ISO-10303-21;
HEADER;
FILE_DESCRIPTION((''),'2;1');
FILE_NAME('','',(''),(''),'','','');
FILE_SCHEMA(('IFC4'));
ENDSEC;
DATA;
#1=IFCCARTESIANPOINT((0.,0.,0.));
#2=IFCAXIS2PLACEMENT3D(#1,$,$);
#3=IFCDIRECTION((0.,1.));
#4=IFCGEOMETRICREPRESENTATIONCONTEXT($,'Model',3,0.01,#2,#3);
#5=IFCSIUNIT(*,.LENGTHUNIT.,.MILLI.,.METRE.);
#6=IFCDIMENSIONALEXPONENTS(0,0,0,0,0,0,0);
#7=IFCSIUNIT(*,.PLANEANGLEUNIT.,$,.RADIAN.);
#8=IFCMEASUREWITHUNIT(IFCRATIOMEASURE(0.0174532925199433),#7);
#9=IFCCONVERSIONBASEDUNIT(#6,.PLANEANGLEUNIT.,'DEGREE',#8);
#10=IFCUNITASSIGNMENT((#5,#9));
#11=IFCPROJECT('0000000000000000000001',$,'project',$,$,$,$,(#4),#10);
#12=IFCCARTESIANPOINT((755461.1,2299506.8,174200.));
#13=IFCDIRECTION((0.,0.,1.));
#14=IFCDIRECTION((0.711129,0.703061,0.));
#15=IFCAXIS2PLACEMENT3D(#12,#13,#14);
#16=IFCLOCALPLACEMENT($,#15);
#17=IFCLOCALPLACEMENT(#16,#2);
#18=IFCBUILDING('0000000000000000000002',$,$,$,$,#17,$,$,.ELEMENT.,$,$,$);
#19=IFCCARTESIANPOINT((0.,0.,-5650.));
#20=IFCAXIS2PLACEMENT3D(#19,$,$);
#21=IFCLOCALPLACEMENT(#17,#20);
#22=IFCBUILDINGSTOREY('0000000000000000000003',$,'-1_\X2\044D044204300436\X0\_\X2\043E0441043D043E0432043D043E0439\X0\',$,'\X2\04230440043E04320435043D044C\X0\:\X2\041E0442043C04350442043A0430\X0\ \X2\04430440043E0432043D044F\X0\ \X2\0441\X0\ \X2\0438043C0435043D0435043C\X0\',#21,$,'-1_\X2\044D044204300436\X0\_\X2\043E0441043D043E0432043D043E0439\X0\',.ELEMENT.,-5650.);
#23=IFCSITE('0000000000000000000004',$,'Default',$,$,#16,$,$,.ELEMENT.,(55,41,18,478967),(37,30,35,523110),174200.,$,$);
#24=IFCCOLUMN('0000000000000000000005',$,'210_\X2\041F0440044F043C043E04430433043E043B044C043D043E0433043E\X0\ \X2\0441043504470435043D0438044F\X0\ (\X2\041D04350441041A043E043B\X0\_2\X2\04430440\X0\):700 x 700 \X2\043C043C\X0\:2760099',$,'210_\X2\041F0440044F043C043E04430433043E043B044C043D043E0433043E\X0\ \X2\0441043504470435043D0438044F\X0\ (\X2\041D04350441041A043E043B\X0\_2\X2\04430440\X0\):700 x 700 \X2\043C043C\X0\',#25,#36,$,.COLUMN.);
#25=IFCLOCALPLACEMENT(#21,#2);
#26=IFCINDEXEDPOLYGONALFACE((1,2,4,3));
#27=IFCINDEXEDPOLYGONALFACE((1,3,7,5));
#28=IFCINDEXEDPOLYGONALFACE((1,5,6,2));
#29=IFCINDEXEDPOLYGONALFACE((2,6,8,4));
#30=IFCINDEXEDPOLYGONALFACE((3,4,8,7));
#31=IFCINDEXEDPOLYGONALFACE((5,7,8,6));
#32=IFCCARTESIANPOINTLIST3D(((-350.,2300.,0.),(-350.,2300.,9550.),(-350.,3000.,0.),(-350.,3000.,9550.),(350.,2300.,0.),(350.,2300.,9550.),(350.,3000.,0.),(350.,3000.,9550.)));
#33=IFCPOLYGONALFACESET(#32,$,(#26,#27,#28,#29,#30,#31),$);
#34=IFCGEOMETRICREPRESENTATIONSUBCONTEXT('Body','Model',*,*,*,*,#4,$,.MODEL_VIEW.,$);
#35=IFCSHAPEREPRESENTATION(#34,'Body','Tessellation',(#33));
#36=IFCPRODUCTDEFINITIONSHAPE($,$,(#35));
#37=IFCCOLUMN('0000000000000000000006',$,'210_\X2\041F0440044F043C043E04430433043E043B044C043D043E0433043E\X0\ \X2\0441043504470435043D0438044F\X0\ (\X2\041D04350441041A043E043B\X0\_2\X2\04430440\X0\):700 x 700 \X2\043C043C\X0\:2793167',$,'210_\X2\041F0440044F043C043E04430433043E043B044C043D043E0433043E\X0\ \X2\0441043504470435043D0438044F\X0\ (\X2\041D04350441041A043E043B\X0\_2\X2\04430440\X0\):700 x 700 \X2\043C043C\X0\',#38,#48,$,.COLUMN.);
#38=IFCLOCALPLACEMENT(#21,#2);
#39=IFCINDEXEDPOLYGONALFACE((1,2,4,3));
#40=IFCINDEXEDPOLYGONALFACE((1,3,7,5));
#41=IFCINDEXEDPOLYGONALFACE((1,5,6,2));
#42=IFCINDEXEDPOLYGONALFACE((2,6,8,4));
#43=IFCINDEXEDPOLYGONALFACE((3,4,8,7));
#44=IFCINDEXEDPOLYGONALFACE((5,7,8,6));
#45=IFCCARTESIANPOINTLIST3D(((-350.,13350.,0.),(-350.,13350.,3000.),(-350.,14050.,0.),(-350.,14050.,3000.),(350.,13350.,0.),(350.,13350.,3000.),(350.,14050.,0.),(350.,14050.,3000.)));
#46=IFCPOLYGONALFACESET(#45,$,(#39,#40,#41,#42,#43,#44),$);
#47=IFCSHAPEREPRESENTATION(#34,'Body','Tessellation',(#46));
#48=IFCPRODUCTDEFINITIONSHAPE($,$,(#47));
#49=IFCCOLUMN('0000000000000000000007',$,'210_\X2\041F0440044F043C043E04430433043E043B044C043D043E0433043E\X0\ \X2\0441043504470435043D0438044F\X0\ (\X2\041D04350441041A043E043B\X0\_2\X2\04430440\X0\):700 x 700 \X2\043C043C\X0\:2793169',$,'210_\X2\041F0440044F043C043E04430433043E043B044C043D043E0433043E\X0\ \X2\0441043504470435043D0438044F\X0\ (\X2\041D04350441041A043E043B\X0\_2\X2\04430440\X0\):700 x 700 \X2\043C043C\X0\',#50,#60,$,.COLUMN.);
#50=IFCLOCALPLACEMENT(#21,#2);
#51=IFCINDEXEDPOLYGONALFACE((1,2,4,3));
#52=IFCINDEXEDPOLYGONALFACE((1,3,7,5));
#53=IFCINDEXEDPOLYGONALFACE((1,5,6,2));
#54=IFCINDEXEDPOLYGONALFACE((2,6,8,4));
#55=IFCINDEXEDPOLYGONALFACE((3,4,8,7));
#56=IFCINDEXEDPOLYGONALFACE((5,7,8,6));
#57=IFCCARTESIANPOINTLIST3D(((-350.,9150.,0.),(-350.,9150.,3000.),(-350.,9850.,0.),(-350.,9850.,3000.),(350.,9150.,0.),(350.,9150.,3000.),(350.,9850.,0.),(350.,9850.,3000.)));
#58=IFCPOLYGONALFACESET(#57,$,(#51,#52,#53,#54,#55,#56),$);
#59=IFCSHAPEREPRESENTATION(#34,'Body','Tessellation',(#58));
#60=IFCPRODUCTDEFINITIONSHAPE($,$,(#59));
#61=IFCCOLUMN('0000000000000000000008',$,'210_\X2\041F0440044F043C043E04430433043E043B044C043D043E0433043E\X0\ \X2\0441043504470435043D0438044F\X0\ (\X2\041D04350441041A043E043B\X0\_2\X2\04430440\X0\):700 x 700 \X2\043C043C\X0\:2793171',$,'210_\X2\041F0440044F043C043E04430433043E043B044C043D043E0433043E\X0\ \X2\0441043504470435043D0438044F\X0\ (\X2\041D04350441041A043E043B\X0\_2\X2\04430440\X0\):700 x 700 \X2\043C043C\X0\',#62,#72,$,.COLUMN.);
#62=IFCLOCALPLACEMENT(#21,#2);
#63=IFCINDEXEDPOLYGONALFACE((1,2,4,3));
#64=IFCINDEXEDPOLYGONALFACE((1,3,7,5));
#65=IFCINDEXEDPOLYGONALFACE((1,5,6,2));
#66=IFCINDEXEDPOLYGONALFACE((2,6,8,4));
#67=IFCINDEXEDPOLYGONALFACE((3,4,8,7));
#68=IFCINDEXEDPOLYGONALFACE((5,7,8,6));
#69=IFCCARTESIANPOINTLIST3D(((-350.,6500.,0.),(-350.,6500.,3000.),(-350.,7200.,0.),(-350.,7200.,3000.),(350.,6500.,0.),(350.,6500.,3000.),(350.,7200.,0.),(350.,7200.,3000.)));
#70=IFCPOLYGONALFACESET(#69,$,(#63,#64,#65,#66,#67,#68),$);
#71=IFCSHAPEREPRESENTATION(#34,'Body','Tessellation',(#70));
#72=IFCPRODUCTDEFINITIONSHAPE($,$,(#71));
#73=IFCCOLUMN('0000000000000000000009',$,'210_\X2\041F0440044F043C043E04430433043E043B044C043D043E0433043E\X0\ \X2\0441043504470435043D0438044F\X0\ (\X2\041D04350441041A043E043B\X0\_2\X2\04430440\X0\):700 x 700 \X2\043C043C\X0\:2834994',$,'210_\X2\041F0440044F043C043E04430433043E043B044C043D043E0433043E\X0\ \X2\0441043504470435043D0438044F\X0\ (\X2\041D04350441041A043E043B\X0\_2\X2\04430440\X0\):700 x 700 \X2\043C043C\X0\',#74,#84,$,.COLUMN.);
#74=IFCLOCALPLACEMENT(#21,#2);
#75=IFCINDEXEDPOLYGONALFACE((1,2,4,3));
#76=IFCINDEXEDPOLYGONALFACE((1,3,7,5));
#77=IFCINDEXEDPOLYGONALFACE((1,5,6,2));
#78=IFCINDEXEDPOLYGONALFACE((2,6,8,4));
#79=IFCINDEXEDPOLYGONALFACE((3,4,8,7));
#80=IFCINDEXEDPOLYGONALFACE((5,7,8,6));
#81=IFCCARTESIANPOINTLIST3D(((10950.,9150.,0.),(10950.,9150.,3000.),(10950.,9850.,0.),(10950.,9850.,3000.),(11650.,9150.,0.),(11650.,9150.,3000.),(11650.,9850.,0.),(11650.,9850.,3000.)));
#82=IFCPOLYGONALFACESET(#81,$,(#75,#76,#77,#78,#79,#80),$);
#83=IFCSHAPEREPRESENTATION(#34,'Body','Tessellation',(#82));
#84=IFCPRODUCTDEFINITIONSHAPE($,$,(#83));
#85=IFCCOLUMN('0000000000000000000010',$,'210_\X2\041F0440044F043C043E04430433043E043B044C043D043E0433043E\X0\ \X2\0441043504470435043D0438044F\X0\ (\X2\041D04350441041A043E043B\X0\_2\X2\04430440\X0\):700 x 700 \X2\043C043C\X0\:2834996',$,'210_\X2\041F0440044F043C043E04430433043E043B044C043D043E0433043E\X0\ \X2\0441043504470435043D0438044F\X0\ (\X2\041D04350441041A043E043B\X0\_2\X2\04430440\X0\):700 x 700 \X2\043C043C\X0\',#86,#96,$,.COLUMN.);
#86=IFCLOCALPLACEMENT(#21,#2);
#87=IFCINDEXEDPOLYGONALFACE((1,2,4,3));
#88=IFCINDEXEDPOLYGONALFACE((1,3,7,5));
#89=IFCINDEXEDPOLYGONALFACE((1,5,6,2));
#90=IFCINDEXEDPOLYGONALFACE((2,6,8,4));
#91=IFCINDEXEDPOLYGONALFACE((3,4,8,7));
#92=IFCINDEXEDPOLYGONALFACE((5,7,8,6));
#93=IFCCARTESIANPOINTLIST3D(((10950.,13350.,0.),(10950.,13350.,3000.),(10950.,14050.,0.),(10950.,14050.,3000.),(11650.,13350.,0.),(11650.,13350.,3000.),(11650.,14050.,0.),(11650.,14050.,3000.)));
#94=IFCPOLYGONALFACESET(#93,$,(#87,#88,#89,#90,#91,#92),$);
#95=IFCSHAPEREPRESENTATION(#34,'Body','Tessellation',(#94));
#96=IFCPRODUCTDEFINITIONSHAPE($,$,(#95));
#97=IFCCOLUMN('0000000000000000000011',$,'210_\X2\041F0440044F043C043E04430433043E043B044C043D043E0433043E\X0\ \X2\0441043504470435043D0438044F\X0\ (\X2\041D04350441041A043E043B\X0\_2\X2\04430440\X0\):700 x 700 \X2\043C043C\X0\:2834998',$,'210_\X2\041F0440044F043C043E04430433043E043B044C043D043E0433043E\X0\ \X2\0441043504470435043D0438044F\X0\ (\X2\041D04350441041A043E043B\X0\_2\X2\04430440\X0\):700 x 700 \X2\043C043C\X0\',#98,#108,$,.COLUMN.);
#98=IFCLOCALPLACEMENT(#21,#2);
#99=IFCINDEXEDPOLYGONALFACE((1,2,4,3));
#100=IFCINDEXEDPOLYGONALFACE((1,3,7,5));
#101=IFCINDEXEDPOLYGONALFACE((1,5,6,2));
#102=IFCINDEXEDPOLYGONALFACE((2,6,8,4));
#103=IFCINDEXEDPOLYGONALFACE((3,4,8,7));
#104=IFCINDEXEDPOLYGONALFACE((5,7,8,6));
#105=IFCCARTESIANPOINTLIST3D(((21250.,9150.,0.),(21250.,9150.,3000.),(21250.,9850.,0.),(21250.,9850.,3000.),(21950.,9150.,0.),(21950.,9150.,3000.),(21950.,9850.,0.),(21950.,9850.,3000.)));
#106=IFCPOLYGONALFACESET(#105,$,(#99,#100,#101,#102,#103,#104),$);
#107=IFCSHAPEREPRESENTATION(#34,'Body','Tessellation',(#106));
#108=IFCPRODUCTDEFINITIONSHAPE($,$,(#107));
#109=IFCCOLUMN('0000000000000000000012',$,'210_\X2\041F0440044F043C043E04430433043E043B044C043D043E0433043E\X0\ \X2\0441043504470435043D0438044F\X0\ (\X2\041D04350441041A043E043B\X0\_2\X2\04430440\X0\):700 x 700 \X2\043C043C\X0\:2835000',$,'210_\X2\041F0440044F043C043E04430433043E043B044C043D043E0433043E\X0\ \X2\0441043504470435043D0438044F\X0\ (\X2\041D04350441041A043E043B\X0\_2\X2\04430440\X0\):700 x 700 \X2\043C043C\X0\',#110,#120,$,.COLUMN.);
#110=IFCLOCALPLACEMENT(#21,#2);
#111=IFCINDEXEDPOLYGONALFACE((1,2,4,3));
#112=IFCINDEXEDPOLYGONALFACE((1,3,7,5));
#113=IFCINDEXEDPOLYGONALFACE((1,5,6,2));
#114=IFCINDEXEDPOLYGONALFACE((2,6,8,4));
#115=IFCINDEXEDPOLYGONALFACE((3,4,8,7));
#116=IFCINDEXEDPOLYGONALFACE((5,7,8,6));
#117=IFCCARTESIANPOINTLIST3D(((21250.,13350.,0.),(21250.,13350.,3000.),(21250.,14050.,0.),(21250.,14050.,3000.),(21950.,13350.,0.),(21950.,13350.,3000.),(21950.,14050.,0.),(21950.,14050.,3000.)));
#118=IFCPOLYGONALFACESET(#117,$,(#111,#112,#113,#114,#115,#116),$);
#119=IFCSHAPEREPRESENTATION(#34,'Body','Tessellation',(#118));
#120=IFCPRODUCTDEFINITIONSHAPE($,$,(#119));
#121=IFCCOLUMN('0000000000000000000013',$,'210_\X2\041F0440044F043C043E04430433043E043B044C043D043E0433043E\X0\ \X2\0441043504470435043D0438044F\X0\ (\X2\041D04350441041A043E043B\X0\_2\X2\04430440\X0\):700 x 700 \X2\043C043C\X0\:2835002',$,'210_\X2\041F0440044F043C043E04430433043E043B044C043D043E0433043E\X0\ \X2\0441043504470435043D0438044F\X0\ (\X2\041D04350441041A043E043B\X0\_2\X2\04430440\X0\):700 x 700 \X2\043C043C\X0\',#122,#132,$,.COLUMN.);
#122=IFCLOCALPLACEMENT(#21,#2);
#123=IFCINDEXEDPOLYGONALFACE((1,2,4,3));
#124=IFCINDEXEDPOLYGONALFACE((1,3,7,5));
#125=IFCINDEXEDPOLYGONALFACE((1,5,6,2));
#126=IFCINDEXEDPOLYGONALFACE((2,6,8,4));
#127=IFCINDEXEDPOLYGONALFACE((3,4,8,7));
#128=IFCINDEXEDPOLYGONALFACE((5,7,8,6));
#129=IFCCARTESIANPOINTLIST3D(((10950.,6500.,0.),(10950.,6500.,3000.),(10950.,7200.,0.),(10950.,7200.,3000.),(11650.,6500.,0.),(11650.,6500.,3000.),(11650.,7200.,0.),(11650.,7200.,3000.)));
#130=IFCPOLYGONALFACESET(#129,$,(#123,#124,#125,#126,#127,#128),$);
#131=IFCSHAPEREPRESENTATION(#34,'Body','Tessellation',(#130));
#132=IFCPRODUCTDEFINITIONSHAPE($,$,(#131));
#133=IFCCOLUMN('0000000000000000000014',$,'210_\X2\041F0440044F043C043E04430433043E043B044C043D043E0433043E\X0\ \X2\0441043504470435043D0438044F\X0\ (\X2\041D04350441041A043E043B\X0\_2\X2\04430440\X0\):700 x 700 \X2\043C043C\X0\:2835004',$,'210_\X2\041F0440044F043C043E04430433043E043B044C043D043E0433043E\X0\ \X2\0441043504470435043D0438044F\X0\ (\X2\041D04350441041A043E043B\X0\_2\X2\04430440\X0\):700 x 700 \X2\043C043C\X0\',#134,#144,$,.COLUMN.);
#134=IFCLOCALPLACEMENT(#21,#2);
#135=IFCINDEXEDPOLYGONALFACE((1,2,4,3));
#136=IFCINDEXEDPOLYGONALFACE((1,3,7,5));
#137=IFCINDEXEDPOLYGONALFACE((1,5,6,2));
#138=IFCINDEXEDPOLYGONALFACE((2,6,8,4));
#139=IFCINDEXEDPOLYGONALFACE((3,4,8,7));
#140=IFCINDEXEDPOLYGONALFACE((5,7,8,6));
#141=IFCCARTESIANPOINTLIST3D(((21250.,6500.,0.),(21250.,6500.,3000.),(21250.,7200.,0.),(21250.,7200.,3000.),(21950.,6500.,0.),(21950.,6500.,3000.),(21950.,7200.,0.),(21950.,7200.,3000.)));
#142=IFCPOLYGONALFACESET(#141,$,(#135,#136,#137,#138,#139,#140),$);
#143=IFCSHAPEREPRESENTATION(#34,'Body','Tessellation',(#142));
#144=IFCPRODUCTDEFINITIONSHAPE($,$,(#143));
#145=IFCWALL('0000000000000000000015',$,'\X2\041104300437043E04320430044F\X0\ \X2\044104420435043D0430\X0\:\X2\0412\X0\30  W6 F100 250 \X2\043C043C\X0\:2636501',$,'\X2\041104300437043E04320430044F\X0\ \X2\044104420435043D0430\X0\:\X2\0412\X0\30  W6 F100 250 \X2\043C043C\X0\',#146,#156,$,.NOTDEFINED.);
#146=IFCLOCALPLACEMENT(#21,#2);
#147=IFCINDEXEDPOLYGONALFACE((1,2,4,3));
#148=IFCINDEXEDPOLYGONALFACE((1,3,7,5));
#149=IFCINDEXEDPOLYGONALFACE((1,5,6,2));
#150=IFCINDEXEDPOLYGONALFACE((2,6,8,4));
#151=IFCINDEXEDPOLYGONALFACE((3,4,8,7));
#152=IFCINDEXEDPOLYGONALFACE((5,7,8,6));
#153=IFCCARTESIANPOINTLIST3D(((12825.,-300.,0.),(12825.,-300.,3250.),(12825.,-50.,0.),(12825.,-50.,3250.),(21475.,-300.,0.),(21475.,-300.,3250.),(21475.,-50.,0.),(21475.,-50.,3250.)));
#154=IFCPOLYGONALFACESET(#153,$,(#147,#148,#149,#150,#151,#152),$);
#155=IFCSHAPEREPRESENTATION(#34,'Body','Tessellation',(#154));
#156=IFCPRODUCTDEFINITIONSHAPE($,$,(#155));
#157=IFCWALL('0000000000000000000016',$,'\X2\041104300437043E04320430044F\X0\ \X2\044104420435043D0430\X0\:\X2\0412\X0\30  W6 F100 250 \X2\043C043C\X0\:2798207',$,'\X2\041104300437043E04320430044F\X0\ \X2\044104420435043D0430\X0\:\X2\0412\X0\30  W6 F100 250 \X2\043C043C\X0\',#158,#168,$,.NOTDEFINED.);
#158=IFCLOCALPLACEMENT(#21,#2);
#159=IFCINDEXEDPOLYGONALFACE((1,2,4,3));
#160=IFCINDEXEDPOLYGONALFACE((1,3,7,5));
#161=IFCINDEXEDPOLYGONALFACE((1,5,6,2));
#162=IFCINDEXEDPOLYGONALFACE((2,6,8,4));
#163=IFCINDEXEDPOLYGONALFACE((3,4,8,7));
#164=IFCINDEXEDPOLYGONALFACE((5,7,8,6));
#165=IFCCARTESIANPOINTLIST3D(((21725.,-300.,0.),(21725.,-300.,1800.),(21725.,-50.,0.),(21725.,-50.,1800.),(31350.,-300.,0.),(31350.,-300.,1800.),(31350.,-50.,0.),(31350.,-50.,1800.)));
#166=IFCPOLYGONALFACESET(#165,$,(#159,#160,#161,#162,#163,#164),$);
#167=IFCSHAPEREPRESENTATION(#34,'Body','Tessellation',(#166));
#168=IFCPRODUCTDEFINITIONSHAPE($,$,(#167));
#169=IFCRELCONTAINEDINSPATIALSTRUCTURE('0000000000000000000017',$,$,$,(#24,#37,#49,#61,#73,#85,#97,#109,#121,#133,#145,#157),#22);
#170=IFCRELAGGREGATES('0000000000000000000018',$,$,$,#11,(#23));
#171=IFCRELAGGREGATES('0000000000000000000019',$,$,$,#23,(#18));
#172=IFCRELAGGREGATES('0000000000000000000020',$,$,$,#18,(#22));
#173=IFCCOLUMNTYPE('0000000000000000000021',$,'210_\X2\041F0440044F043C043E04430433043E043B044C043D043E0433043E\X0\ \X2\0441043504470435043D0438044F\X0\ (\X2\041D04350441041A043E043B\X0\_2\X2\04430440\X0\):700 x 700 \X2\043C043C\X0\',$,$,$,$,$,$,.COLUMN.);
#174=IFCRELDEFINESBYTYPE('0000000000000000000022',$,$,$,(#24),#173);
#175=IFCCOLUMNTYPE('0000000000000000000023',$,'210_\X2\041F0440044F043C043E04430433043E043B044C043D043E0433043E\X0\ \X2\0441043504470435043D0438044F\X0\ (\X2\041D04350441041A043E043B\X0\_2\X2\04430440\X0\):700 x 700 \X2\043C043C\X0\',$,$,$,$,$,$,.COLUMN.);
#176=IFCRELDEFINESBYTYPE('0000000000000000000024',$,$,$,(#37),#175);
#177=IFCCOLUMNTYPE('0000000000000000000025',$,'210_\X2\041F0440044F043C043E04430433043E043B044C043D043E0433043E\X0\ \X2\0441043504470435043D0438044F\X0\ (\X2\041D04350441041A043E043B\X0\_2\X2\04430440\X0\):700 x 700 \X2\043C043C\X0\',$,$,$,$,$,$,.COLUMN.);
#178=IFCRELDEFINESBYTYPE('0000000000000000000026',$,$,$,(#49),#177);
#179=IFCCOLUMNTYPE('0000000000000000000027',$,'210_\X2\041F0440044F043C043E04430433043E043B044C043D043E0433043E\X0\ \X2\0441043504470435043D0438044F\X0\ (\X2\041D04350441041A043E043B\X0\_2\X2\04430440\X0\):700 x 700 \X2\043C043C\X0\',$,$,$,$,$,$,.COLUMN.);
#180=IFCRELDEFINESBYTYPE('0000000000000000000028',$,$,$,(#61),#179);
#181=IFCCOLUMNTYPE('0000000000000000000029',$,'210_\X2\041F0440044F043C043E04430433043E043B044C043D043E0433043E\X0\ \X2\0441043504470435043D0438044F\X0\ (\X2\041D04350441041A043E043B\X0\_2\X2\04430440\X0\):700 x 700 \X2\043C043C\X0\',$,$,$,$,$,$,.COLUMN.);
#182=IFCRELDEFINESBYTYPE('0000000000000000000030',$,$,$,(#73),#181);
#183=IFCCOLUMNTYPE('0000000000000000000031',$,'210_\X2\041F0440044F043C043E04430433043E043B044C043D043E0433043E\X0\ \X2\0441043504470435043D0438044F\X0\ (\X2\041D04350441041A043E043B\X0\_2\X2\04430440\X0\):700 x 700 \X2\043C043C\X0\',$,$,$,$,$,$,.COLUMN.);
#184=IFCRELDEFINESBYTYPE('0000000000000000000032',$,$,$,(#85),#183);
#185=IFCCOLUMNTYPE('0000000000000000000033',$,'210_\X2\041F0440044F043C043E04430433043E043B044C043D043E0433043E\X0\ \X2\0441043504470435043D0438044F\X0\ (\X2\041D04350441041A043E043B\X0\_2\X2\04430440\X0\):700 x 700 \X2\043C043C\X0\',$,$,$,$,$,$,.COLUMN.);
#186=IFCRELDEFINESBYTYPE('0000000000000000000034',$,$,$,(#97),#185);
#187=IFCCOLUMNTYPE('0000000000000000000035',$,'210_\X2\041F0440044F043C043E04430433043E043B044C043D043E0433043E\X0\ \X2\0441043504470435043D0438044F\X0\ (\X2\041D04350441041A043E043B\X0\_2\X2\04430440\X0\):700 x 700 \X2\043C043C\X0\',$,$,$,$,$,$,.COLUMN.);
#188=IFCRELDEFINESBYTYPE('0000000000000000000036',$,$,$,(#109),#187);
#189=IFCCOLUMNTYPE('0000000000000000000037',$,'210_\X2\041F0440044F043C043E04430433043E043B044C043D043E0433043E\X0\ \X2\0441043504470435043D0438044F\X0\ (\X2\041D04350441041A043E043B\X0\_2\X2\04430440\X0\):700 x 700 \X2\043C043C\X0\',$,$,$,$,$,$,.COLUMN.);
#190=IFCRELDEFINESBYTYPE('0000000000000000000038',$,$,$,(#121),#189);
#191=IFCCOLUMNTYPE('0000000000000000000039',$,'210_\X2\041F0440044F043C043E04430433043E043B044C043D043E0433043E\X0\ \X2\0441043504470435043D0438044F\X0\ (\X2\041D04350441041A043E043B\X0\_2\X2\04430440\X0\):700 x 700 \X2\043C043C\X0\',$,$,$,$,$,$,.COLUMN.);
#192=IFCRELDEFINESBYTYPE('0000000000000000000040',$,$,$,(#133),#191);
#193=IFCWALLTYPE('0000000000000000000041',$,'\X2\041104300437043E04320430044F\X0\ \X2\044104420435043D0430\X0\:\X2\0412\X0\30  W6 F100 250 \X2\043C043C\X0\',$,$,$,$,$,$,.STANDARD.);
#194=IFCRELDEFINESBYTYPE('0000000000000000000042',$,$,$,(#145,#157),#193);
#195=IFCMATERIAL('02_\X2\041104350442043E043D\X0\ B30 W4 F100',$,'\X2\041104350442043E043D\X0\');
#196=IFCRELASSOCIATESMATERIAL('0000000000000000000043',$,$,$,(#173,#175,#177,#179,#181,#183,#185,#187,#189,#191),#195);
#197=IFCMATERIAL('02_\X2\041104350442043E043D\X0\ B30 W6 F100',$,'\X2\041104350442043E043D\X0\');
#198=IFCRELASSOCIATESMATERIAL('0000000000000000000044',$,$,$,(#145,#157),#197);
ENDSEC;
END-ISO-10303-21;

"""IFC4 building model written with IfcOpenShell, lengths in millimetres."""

from ifc_helpers import new_model, entity, si_unit, converted_unit, direction, frame, origin, place, context, subcontext, project, spatial, indexed_curve, outline, extrude, source, transform, mapped, material, type_object, type_shapes, element, save


model = new_model("IFC4")

# Units and contexts
model_context = context("Model", 3, precision=0.01, world=origin(), true_north=direction((0.0, 1.0)))
body_context = subcontext(model_context, "Body", "Model", "MODEL_VIEW")
ifc_project = project(units=[si_unit("LENGTHUNIT", "METRE", prefix="MILLI"), converted_unit("PLANEANGLEUNIT", "DEGREE", entity("IfcRatioMeasure", 0.0174532925199433), si_unit("PLANEANGLEUNIT", "RADIAN"), dimensions=[0, 0, 0, 0, 0, 0, 0])], contexts=[model_context])

# Site, building, storey
site_placement = place(None, frame((755461.1, 2299506.8, 174200.0), z_axis=(0.0, 0.0, 1.0), x_axis=(0.711129, 0.703061, 0.0)))
site = spatial("IfcSite", under=ifc_project, at=site_placement, Name="Default", CompositionType="ELEMENT", RefLatitude=(55, 41, 18, 478967), RefLongitude=(37, 30, 35, 523110), RefElevation=174200.0)
building_placement = place(site_placement, origin())
building = spatial("IfcBuilding", under=site, at=building_placement, CompositionType="ELEMENT")
storey_placement = place(building_placement, frame((0.0, 0.0, -5650.0)))
storey = spatial("IfcBuildingStorey", under=building, at=storey_placement, Name="-1_этаж_основной", ObjectType="Уровень:Отметка уровня с именем", LongName="-1_этаж_основной", CompositionType="ELEMENT", Elevation=-5650.0)

# Columns
ifc_material_1 = material(Name="02_Бетон B30 W4 F100", Category="Бетон")
column_type_1 = type_object("IfcColumnType", Name="210_Прямоугольного сечения (НесКол_2ур):700 x 700 мм", PredefinedType="COLUMN", material=ifc_material_1)
shared_shape_1 = source(origin(), body_context, "Body", "SweptSolid", [
    extrude(outline(indexed_curve([(-350.0, -350.0), (350.0, -350.0), (350.0, 350.0), (-350.0, 350.0), (-350.0, -350.0)], self_intersect=False)), frame((0.0, 2650.0, -5650.0), z_axis=(0.0, 0.0, 1.0), x_axis=(0.0, -1.0, 0.0)), (0.0, 0.0, 1.0), 9550.0),
])
type_shapes(column_type_1, [shared_shape_1])
column_1_placement = place(storey_placement, frame((0.0, 0.0, 5650.0)))
element("IfcColumn", 1, at=column_1_placement, inside=storey, type_object=column_type_1, Name="210_Прямоугольного сечения (НесКол_2ур):700 x 700 мм:2760099", ObjectType="210_Прямоугольного сечения (НесКол_2ур):700 x 700 мм", PredefinedType="COLUMN", context=body_context, shape_type="MappedRepresentation", body=[
    mapped(shared_shape_1, transform((0.0, 0.0, 0.0), scale=1.0)),
])
column_type_2 = type_object("IfcColumnType", Name="210_Прямоугольного сечения (НесКол_2ур):700 x 700 мм", PredefinedType="COLUMN", material=ifc_material_1)
shared_shape_2 = source(origin(), body_context, "Body", "SweptSolid", [
    extrude(outline(indexed_curve([(-350.0, -350.0), (350.0, -350.0), (350.0, 350.0), (-350.0, 350.0), (-350.0, -350.0)], self_intersect=False)), frame((0.0, 13700.0, -5650.0), z_axis=(0.0, 0.0, 1.0), x_axis=(0.0, -1.0, 0.0)), (0.0, 0.0, 1.0), 3000.0),
])
type_shapes(column_type_2, [shared_shape_2])
column_2_placement = place(storey_placement, frame((0.0, 0.0, 5650.0)))
element("IfcColumn", 2, at=column_2_placement, inside=storey, type_object=column_type_2, Name="210_Прямоугольного сечения (НесКол_2ур):700 x 700 мм:2793167", ObjectType="210_Прямоугольного сечения (НесКол_2ур):700 x 700 мм", PredefinedType="COLUMN", context=body_context, shape_type="MappedRepresentation", body=[
    mapped(shared_shape_2, transform((0.0, 0.0, 0.0), scale=1.0)),
])
column_type_3 = type_object("IfcColumnType", Name="210_Прямоугольного сечения (НесКол_2ур):700 x 700 мм", PredefinedType="COLUMN", material=ifc_material_1)
shared_shape_3 = source(origin(), body_context, "Body", "SweptSolid", [
    extrude(outline(indexed_curve([(-350.0, -350.0), (350.0, -350.0), (350.0, 350.0), (-350.0, 350.0), (-350.0, -350.0)], self_intersect=False)), frame((0.0, 9500.0, -5650.0), z_axis=(0.0, 0.0, 1.0), x_axis=(0.0, -1.0, 0.0)), (0.0, 0.0, 1.0), 3000.0),
])
type_shapes(column_type_3, [shared_shape_3])
column_3_placement = place(storey_placement, frame((0.0, 0.0, 5650.0)))
element("IfcColumn", 3, at=column_3_placement, inside=storey, type_object=column_type_3, Name="210_Прямоугольного сечения (НесКол_2ур):700 x 700 мм:2793169", ObjectType="210_Прямоугольного сечения (НесКол_2ур):700 x 700 мм", PredefinedType="COLUMN", context=body_context, shape_type="MappedRepresentation", body=[
    mapped(shared_shape_3, transform((0.0, 0.0, 0.0), scale=1.0)),
])
column_type_4 = type_object("IfcColumnType", Name="210_Прямоугольного сечения (НесКол_2ур):700 x 700 мм", PredefinedType="COLUMN", material=ifc_material_1)
shared_shape_4 = source(origin(), body_context, "Body", "SweptSolid", [
    extrude(outline(indexed_curve([(-350.0, -350.0), (350.0, -350.0), (350.0, 350.0), (-350.0, 350.0), (-350.0, -350.0)], self_intersect=False)), frame((0.0, 6850.0, -5650.0), z_axis=(0.0, 0.0, 1.0), x_axis=(0.0, -1.0, 0.0)), (0.0, 0.0, 1.0), 3000.0),
])
type_shapes(column_type_4, [shared_shape_4])
column_4_placement = place(storey_placement, frame((0.0, 0.0, 5650.0)))
element("IfcColumn", 4, at=column_4_placement, inside=storey, type_object=column_type_4, Name="210_Прямоугольного сечения (НесКол_2ур):700 x 700 мм:2793171", ObjectType="210_Прямоугольного сечения (НесКол_2ур):700 x 700 мм", PredefinedType="COLUMN", context=body_context, shape_type="MappedRepresentation", body=[
    mapped(shared_shape_4, transform((0.0, 0.0, 0.0), scale=1.0)),
])
column_type_5 = type_object("IfcColumnType", Name="210_Прямоугольного сечения (НесКол_2ур):700 x 700 мм", PredefinedType="COLUMN", material=ifc_material_1)
shared_shape_5 = source(origin(), body_context, "Body", "SweptSolid", [
    extrude(outline(indexed_curve([(-350.0, -350.0), (350.0, -350.0), (350.0, 350.0), (-350.0, 350.0), (-350.0, -350.0)], self_intersect=False)), frame((11300.0, 9500.0, -5650.0), z_axis=(0.0, 0.0, 1.0), x_axis=(0.0, -1.0, 0.0)), (0.0, 0.0, 1.0), 3000.0),
])
type_shapes(column_type_5, [shared_shape_5])
column_5_placement = place(storey_placement, frame((0.0, 0.0, 5650.0)))
element("IfcColumn", 5, at=column_5_placement, inside=storey, type_object=column_type_5, Name="210_Прямоугольного сечения (НесКол_2ур):700 x 700 мм:2834994", ObjectType="210_Прямоугольного сечения (НесКол_2ур):700 x 700 мм", PredefinedType="COLUMN", context=body_context, shape_type="MappedRepresentation", body=[
    mapped(shared_shape_5, transform((0.0, 0.0, 0.0), scale=1.0)),
])
column_type_6 = type_object("IfcColumnType", Name="210_Прямоугольного сечения (НесКол_2ур):700 x 700 мм", PredefinedType="COLUMN", material=ifc_material_1)
shared_shape_6 = source(origin(), body_context, "Body", "SweptSolid", [
    extrude(outline(indexed_curve([(-350.0, -350.0), (350.0, -350.0), (350.0, 350.0), (-350.0, 350.0), (-350.0, -350.0)], self_intersect=False)), frame((11300.0, 13700.0, -5650.0), z_axis=(0.0, 0.0, 1.0), x_axis=(0.0, -1.0, 0.0)), (0.0, 0.0, 1.0), 3000.0),
])
type_shapes(column_type_6, [shared_shape_6])
column_6_placement = place(storey_placement, frame((0.0, 0.0, 5650.0)))
element("IfcColumn", 6, at=column_6_placement, inside=storey, type_object=column_type_6, Name="210_Прямоугольного сечения (НесКол_2ур):700 x 700 мм:2834996", ObjectType="210_Прямоугольного сечения (НесКол_2ур):700 x 700 мм", PredefinedType="COLUMN", context=body_context, shape_type="MappedRepresentation", body=[
    mapped(shared_shape_6, transform((0.0, 0.0, 0.0), scale=1.0)),
])
column_type_7 = type_object("IfcColumnType", Name="210_Прямоугольного сечения (НесКол_2ур):700 x 700 мм", PredefinedType="COLUMN", material=ifc_material_1)
shared_shape_7 = source(origin(), body_context, "Body", "SweptSolid", [
    extrude(outline(indexed_curve([(-350.0, -350.0), (350.0, -350.0), (350.0, 350.0), (-350.0, 350.0), (-350.0, -350.0)], self_intersect=False)), frame((21600.0, 9500.0, -5650.0), z_axis=(0.0, 0.0, 1.0), x_axis=(0.0, -1.0, 0.0)), (0.0, 0.0, 1.0), 3000.0),
])
type_shapes(column_type_7, [shared_shape_7])
column_7_placement = place(storey_placement, frame((0.0, 0.0, 5650.0)))
element("IfcColumn", 7, at=column_7_placement, inside=storey, type_object=column_type_7, Name="210_Прямоугольного сечения (НесКол_2ур):700 x 700 мм:2834998", ObjectType="210_Прямоугольного сечения (НесКол_2ур):700 x 700 мм", PredefinedType="COLUMN", context=body_context, shape_type="MappedRepresentation", body=[
    mapped(shared_shape_7, transform((0.0, 0.0, 0.0), scale=1.0)),
])
column_type_8 = type_object("IfcColumnType", Name="210_Прямоугольного сечения (НесКол_2ур):700 x 700 мм", PredefinedType="COLUMN", material=ifc_material_1)
shared_shape_8 = source(origin(), body_context, "Body", "SweptSolid", [
    extrude(outline(indexed_curve([(-350.0, -350.0), (350.0, -350.0), (350.0, 350.0), (-350.0, 350.0), (-350.0, -350.0)], self_intersect=False)), frame((21600.0, 13700.0, -5650.0), z_axis=(0.0, 0.0, 1.0), x_axis=(0.0, -1.0, 0.0)), (0.0, 0.0, 1.0), 3000.0),
])
type_shapes(column_type_8, [shared_shape_8])
column_8_placement = place(storey_placement, frame((0.0, 0.0, 5650.0)))
element("IfcColumn", 8, at=column_8_placement, inside=storey, type_object=column_type_8, Name="210_Прямоугольного сечения (НесКол_2ур):700 x 700 мм:2835000", ObjectType="210_Прямоугольного сечения (НесКол_2ур):700 x 700 мм", PredefinedType="COLUMN", context=body_context, shape_type="MappedRepresentation", body=[
    mapped(shared_shape_8, transform((0.0, 0.0, 0.0), scale=1.0)),
])
column_type_9 = type_object("IfcColumnType", Name="210_Прямоугольного сечения (НесКол_2ур):700 x 700 мм", PredefinedType="COLUMN", material=ifc_material_1)
shared_shape_9 = source(origin(), body_context, "Body", "SweptSolid", [
    extrude(outline(indexed_curve([(-350.0, -350.0), (350.0, -350.0), (350.0, 350.0), (-350.0, 350.0), (-350.0, -350.0)], self_intersect=False)), frame((11300.0, 6850.0, -5650.0), z_axis=(0.0, 0.0, 1.0), x_axis=(0.0, -1.0, 0.0)), (0.0, 0.0, 1.0), 3000.0),
])
type_shapes(column_type_9, [shared_shape_9])
column_9_placement = place(storey_placement, frame((0.0, 0.0, 5650.0)))
element("IfcColumn", 9, at=column_9_placement, inside=storey, type_object=column_type_9, Name="210_Прямоугольного сечения (НесКол_2ур):700 x 700 мм:2835002", ObjectType="210_Прямоугольного сечения (НесКол_2ур):700 x 700 мм", PredefinedType="COLUMN", context=body_context, shape_type="MappedRepresentation", body=[
    mapped(shared_shape_9, transform((0.0, 0.0, 0.0), scale=1.0)),
])
column_type_10 = type_object("IfcColumnType", Name="210_Прямоугольного сечения (НесКол_2ур):700 x 700 мм", PredefinedType="COLUMN", material=ifc_material_1)
shared_shape_10 = source(origin(), body_context, "Body", "SweptSolid", [
    extrude(outline(indexed_curve([(-350.0, -350.0), (350.0, -350.0), (350.0, 350.0), (-350.0, 350.0), (-350.0, -350.0)], self_intersect=False)), frame((21600.0, 6850.0, -5650.0), z_axis=(0.0, 0.0, 1.0), x_axis=(0.0, -1.0, 0.0)), (0.0, 0.0, 1.0), 3000.0),
])
type_shapes(column_type_10, [shared_shape_10])
column_10_placement = place(storey_placement, frame((0.0, 0.0, 5650.0)))
element("IfcColumn", 10, at=column_10_placement, inside=storey, type_object=column_type_10, Name="210_Прямоугольного сечения (НесКол_2ур):700 x 700 мм:2835004", ObjectType="210_Прямоугольного сечения (НесКол_2ур):700 x 700 мм", PredefinedType="COLUMN", context=body_context, shape_type="MappedRepresentation", body=[
    mapped(shared_shape_10, transform((0.0, 0.0, 0.0), scale=1.0)),
])

# Shared definitions
ifc_material_2 = material(Name="02_Бетон B30 W6 F100", Category="Бетон")

# Walls
wall_type = type_object("IfcWallType", Name="Базовая стена:В30  W6 F100 250 мм", PredefinedType="STANDARD")
wall_1_placement = place(storey_placement, frame((12825.0, -175.0, 0.0)))
element("IfcWall", 11, at=wall_1_placement, inside=storey, type_object=wall_type, material=ifc_material_2, Name="Базовая стена:В30  W6 F100 250 мм:2636501", ObjectType="Базовая стена:В30  W6 F100 250 мм", PredefinedType="NOTDEFINED", context=body_context, shape_type="SweptSolid", body=[
    extrude(outline(indexed_curve([(8650.0, 125.0), (0.0, 125.0), (0.0, -125.0), (8650.0, -125.0), (8650.0, 125.0)], self_intersect=False)), origin(), (0.0, 0.0, 1.0), 3250.0),
])
wall_2_placement = place(storey_placement, frame((21725.0, -175.0, 0.0)))
element("IfcWall", 12, at=wall_2_placement, inside=storey, type_object=wall_type, material=ifc_material_2, Name="Базовая стена:В30  W6 F100 250 мм:2798207", ObjectType="Базовая стена:В30  W6 F100 250 мм", PredefinedType="NOTDEFINED", context=body_context, shape_type="SweptSolid", body=[
    extrude(outline(indexed_curve([(9625.0, 125.0), (0.0, 125.0), (0.0, -125.0), (9625.0, -125.0), (9625.0, 125.0)], self_intersect=False)), origin(), (0.0, 0.0, 1.0), 1800.0),
])

save(model, "model.ifc")
